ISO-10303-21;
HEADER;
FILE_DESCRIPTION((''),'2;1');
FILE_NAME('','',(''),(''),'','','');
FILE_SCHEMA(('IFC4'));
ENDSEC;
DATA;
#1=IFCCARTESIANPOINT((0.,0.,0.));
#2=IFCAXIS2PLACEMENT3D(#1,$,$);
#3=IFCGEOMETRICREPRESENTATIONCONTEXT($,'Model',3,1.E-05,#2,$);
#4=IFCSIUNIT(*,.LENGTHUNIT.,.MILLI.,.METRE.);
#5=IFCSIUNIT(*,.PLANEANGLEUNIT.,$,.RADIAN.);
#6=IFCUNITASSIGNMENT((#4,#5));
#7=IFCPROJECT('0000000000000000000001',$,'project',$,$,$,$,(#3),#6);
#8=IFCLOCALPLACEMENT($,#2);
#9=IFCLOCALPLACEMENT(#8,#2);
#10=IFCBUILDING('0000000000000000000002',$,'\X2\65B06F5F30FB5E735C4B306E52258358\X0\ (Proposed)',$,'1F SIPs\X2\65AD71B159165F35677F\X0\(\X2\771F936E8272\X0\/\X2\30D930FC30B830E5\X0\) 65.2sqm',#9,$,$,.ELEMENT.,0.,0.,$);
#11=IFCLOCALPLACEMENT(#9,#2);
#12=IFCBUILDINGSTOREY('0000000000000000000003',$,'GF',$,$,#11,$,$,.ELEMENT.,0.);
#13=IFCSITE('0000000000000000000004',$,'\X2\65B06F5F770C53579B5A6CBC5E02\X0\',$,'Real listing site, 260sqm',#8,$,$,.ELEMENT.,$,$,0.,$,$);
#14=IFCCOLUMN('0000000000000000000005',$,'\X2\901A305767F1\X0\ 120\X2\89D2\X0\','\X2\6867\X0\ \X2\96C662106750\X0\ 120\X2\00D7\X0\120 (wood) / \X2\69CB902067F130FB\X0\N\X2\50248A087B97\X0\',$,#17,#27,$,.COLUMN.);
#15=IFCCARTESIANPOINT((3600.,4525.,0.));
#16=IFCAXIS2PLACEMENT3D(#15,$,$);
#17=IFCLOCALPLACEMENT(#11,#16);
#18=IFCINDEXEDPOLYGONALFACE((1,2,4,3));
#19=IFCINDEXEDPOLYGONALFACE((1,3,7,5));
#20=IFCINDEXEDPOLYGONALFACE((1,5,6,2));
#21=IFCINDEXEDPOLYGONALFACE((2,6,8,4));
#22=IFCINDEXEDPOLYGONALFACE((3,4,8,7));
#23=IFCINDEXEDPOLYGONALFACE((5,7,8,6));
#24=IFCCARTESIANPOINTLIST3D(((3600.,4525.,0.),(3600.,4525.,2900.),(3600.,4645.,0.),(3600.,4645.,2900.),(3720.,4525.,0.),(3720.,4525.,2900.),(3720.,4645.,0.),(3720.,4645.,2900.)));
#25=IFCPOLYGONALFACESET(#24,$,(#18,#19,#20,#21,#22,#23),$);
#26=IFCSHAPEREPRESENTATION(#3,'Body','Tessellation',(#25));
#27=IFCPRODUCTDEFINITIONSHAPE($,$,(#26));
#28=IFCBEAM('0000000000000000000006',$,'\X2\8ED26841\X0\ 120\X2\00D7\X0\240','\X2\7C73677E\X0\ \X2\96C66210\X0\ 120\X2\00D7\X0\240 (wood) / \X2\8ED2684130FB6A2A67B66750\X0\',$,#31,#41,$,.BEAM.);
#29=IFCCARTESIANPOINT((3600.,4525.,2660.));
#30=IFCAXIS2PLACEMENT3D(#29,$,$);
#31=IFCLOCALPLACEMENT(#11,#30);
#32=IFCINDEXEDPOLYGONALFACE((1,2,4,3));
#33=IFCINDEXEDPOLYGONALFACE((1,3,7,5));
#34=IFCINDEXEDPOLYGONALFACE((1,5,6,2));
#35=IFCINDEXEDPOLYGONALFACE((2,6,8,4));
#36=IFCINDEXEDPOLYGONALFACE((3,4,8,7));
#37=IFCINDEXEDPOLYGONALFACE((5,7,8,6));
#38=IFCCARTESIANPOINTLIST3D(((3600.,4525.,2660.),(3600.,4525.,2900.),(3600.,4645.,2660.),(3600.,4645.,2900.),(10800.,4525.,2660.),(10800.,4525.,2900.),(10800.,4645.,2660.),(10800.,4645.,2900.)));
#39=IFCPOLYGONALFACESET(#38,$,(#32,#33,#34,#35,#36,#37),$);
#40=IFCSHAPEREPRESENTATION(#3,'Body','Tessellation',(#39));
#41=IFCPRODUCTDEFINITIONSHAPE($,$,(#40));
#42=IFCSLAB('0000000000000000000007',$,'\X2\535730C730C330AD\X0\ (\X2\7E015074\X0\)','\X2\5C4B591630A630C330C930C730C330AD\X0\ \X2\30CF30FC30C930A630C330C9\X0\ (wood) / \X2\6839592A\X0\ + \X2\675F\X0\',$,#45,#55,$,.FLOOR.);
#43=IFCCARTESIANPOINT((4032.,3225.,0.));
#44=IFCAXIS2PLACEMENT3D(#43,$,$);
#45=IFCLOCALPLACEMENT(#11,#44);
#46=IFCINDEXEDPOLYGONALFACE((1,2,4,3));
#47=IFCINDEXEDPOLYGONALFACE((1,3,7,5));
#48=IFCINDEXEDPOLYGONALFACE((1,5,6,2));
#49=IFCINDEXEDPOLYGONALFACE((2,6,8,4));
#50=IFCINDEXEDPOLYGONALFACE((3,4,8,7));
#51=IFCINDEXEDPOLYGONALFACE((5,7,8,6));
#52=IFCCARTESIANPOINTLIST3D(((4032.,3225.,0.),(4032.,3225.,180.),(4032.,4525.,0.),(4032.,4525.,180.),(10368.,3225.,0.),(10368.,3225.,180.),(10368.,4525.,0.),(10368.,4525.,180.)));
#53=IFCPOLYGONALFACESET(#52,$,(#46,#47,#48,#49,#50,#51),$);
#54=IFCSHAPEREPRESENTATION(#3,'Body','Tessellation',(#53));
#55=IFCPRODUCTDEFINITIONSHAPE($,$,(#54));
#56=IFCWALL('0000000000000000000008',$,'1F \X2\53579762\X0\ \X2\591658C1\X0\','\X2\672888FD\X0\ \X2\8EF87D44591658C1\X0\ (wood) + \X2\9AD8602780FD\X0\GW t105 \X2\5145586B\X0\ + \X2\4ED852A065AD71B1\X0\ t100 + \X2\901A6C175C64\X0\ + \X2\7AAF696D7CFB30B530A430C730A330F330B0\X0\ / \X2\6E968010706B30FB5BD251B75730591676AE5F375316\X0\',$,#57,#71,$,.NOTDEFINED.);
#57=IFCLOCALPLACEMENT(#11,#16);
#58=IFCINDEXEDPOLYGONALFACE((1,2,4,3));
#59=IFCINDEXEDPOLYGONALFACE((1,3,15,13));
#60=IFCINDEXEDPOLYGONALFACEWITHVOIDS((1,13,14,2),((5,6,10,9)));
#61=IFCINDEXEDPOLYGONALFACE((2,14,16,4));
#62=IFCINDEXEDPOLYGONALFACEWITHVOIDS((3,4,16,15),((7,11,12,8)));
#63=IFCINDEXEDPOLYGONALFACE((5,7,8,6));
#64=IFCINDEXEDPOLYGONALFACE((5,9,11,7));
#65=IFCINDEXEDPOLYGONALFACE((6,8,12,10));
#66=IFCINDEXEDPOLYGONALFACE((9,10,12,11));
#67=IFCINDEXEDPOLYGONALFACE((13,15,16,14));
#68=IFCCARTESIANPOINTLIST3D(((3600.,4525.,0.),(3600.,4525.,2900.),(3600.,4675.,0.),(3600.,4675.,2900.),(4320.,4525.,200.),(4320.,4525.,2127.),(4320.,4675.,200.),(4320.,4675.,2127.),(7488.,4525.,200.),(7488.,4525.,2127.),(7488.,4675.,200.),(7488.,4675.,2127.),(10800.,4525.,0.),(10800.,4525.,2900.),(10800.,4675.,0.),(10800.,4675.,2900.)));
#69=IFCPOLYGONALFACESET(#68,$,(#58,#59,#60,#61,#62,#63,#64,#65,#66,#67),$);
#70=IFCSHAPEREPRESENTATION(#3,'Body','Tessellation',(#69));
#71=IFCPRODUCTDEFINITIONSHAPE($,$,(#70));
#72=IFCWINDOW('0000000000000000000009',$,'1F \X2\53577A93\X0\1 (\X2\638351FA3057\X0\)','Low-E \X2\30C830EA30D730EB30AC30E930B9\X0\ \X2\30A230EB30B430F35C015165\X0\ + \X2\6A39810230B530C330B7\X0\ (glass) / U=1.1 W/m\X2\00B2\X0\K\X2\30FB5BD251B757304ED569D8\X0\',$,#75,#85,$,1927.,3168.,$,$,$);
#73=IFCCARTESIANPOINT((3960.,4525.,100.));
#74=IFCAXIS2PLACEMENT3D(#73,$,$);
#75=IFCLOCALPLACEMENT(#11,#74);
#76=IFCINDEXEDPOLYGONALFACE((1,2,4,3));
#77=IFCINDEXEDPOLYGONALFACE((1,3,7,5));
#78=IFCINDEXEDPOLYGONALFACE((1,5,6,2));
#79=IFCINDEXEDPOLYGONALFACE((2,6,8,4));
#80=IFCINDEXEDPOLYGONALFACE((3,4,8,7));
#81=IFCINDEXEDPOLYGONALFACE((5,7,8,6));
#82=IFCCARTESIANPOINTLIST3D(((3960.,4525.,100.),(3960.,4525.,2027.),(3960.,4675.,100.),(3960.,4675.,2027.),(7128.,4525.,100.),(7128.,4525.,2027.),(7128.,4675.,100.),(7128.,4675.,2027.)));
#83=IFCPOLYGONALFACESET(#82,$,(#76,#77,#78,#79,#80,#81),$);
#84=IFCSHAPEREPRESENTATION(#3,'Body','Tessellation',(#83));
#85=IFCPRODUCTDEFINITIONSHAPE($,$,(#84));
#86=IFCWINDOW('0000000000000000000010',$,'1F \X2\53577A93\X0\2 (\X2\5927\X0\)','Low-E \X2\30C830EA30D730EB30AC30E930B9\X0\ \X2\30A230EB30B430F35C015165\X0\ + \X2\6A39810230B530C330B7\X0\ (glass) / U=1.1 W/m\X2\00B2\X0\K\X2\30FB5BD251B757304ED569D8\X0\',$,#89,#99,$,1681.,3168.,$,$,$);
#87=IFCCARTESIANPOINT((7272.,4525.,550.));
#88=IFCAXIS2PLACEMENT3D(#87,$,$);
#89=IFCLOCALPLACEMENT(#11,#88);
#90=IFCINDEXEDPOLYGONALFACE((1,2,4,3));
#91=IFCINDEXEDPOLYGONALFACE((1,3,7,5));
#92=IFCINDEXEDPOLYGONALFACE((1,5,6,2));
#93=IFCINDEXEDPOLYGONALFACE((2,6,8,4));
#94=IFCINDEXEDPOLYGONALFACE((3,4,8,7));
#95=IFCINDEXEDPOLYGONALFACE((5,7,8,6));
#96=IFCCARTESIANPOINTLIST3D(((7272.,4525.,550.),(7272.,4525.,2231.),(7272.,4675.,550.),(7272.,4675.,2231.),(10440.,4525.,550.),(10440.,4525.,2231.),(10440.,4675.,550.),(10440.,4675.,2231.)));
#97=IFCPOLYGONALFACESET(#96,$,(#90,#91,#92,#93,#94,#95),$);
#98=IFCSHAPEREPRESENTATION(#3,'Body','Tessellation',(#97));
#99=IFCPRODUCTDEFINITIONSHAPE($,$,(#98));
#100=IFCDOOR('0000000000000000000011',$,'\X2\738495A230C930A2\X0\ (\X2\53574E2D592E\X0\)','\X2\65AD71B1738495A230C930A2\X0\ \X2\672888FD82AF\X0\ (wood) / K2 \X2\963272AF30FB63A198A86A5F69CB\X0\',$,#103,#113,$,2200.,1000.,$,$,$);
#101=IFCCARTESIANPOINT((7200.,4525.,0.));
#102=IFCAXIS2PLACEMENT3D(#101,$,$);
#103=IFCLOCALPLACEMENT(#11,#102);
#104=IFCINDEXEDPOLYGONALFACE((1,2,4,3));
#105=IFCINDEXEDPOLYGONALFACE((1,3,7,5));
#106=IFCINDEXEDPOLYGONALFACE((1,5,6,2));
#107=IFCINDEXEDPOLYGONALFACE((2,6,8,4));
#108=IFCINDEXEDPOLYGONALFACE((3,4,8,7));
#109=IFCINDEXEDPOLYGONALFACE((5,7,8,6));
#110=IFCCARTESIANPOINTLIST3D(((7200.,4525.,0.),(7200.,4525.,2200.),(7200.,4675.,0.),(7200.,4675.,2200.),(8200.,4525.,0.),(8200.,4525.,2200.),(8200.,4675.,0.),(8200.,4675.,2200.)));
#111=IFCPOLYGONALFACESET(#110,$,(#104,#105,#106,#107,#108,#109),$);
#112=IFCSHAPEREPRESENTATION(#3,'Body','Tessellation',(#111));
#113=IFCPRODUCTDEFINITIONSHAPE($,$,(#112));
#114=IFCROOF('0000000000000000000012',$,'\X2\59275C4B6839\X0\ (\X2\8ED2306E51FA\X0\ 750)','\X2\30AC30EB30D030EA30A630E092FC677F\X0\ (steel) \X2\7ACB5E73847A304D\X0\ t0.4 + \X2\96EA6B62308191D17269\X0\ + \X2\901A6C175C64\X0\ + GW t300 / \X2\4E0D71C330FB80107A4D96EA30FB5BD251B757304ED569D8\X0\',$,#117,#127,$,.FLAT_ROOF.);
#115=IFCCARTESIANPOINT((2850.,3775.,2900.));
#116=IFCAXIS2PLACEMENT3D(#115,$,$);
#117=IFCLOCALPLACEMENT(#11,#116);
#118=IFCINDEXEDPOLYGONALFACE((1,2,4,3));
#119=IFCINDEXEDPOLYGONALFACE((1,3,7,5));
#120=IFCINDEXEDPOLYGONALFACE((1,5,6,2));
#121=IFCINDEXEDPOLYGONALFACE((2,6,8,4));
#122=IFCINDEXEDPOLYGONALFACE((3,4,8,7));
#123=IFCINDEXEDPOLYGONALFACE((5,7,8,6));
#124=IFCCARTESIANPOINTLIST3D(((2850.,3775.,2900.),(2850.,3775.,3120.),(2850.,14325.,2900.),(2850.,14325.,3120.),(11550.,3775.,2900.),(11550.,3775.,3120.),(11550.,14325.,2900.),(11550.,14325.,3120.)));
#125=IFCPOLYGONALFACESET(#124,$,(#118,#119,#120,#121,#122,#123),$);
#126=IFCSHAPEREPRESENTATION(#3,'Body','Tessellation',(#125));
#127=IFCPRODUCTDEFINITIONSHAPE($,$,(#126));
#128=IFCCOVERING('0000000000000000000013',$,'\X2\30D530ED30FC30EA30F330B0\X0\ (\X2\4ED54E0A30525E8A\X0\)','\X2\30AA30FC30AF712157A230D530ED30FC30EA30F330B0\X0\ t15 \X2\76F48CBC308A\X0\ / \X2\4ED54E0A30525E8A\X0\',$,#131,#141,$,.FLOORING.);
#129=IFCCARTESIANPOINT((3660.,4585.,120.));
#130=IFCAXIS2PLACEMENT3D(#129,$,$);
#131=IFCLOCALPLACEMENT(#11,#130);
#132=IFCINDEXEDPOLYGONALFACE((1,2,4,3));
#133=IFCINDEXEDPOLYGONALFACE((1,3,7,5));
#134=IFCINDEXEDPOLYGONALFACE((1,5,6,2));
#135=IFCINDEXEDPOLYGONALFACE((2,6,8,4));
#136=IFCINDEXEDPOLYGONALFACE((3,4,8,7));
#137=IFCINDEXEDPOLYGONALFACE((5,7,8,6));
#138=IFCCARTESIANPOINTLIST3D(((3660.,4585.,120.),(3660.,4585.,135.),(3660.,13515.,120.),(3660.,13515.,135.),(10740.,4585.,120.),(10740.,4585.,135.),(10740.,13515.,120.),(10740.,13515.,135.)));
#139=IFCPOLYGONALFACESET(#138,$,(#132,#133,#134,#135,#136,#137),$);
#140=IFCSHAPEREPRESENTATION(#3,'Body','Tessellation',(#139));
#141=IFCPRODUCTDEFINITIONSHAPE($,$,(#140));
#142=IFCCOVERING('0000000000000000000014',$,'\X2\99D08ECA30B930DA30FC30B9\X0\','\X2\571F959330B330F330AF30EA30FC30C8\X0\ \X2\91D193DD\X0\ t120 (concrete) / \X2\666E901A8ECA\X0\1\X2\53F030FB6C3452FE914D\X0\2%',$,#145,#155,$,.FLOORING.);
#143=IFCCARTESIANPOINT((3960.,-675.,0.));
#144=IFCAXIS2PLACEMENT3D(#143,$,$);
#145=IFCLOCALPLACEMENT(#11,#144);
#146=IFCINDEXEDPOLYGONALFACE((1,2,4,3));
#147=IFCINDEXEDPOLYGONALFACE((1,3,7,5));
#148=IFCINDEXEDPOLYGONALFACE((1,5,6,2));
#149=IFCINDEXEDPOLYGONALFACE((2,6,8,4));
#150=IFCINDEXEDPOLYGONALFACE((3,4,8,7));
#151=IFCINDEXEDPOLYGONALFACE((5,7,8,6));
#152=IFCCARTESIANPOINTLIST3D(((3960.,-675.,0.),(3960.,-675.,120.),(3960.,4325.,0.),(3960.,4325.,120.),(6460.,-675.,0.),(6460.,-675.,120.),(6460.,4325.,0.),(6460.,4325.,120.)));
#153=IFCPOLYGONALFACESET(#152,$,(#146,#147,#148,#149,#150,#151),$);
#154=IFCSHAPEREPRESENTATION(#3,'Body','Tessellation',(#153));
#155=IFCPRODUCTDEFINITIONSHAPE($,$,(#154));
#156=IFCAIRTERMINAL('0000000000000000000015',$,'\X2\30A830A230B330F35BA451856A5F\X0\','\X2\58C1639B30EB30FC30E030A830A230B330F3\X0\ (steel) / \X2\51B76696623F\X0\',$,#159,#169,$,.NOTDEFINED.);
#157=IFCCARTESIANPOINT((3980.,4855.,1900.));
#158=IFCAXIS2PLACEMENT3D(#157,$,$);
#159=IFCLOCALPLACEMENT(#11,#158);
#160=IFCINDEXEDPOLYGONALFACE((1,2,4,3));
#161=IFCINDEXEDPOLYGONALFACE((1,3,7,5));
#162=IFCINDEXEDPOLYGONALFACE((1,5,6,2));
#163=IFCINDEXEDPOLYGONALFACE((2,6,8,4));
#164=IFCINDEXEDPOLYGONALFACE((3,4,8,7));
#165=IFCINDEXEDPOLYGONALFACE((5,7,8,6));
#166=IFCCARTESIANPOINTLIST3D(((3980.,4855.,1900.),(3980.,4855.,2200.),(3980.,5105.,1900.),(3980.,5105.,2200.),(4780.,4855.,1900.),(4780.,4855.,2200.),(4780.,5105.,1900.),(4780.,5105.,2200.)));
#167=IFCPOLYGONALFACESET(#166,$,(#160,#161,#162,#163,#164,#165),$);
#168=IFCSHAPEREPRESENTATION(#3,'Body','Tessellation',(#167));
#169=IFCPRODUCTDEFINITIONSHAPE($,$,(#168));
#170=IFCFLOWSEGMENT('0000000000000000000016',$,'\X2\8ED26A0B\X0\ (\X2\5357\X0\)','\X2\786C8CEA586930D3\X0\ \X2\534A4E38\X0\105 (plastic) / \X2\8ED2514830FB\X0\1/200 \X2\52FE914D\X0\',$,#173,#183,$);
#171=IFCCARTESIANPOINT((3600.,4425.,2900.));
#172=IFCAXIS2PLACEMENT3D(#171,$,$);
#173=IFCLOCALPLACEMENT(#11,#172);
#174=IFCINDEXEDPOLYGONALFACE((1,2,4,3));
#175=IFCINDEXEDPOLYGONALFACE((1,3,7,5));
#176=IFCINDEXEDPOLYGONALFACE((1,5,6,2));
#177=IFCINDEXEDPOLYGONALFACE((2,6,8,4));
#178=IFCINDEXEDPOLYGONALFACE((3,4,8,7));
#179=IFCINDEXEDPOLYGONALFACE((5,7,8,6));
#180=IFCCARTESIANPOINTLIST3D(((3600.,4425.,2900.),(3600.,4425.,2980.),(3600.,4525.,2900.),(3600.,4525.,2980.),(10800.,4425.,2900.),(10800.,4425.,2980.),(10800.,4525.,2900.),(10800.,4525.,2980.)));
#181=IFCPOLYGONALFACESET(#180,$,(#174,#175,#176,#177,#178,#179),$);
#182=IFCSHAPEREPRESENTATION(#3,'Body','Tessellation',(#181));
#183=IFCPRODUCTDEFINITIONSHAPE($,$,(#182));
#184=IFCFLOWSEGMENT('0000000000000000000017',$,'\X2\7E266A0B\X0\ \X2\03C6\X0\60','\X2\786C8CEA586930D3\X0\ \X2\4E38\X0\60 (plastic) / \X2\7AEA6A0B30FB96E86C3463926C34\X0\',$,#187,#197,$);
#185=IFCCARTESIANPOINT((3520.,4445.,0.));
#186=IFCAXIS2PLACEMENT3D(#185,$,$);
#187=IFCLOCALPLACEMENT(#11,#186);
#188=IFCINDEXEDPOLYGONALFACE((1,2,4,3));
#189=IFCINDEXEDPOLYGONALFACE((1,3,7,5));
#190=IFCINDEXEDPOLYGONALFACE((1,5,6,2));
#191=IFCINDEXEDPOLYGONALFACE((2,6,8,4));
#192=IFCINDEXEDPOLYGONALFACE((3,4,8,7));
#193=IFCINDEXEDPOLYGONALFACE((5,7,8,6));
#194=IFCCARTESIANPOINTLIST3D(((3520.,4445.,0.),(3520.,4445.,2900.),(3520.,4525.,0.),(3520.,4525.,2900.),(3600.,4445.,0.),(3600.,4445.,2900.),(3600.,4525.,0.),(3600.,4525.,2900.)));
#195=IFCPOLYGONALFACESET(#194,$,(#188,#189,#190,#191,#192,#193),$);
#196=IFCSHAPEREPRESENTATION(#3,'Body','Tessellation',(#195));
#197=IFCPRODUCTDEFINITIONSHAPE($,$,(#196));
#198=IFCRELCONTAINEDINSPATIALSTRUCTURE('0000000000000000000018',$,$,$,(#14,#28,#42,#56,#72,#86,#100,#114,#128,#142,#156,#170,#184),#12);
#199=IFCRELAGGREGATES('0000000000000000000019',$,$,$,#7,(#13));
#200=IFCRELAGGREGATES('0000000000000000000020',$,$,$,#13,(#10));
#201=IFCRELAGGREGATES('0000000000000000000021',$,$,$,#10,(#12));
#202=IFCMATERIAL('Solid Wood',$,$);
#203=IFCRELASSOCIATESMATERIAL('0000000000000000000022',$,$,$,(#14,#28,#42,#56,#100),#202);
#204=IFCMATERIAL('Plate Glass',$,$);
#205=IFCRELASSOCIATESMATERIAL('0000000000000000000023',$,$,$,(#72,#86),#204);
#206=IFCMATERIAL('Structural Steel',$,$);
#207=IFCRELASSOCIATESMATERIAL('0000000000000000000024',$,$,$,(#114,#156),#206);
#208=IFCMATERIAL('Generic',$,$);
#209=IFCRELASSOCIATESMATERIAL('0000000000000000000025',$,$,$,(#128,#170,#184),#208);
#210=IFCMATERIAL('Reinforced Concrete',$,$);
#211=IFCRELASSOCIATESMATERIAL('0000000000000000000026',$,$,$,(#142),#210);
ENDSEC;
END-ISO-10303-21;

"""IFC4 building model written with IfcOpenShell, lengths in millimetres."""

from ifc_helpers import new_model, si_unit, frame, frame_2d, origin, place, context, project, spatial, rectangle, extrude, material, element, fill, save


model = new_model("IFC4")

# Units and contexts
model_context = context("Model", 3, precision=1e-05, world=origin())
ifc_project = project(units=[si_unit("LENGTHUNIT", "METRE", prefix="MILLI"), si_unit("PLANEANGLEUNIT", "RADIAN")], contexts=[model_context])

# Site, building, storey
site_placement = place(None, origin())
site = spatial("IfcSite", under=ifc_project, at=site_placement, Name="新潟県南魚沼市", ObjectType="Real listing site, 260sqm", CompositionType="ELEMENT", RefElevation=0.0)
building_placement = place(site_placement, origin())
building = spatial("IfcBuilding", under=site, at=building_placement, Name="新潟・平屋の別荘 (Proposed)", ObjectType="1F SIPs断熱外張板(真鍮色/ベージュ) 65.2sqm", CompositionType="ELEMENT", ElevationOfRefHeight=0.0, ElevationOfTerrain=0.0)
storey_placement = place(building_placement, origin())
storey = spatial("IfcBuildingStorey", under=building, at=storey_placement, Name="GF", CompositionType="ELEMENT", Elevation=0.0)

# Column
ifc_material_1 = material(Name="Solid Wood")
column_1_placement = place(storey_placement, frame((3600.0, 4525.0, 0.0)))
element("IfcColumn", 1, at=column_1_placement, inside=storey, material=ifc_material_1, Name="通し柱 120角", Description="桧 集成材 120×120 (wood) / 構造柱・N値計算", PredefinedType="COLUMN", context=model_context, shape_type="SweptSolid", body=[
    extrude(rectangle(XDim=120.0, YDim=120.0, at=frame_2d((60.0, 60.0))), frame((3600.0, 4525.0, 0.0)), (0.0, 0.0, 1.0), 2900.0),
])

# Beam
beam_1_placement = place(storey_placement, frame((3600.0, 4525.0, 2660.0)))
element("IfcBeam", 2, at=beam_1_placement, inside=storey, material=ifc_material_1, Name="軒桁 120×240", Description="米松 集成 120×240 (wood) / 軒桁・横架材", PredefinedType="BEAM", context=model_context, shape_type="SweptSolid", body=[
    extrude(rectangle(XDim=7200.0, YDim=120.0, at=frame_2d((3600.0, 60.0))), frame((3600.0, 4525.0, 2660.0)), (0.0, 0.0, 1.0), 240.0),
])

# Slab
ifc_material_2 = material(Name="Reinforced Concrete")
slab_1_placement = place(storey_placement, frame((4032.0, 3225.0, 0.0)))
element("IfcSlab", 3, at=slab_1_placement, inside=storey, material=ifc_material_1, Name="南デッキ (縁側)", Description="屋外ウッドデッキ ハードウッド (wood) / 根太 + 束", PredefinedType="FLOOR", context=model_context, shape_type="SweptSolid", body=[
    extrude(rectangle(XDim=6336.0, YDim=1300.0, at=frame_2d((3168.0, 650.0))), frame((4032.0, 3225.0, 0.0)), (0.0, 0.0, 1.0), 180.0),
])

# Wall, openings, windows, door
wall_1_placement = place(storey_placement, frame((3600.0, 4525.0, 0.0)))
wall_1 = element("IfcWall", 4, at=wall_1_placement, inside=storey, material=ifc_material_1, Name="1F 南面 外壁", Description="木製 軸組外壁 (wood) + 高性能GW t105 充填 + 付加断熱 t100 + 通気層 + 窯業系サイディング / 準耐火・寒冷地外皮強化", PredefinedType="NOTDEFINED", context=model_context, shape_type="SweptSolid", body=[
    extrude(rectangle(XDim=7200.0, YDim=150.0, at=frame_2d((3600.0, 75.0))), frame((3600.0, 4525.0, 0.0)), (0.0, 0.0, 1.0), 2900.0),
])
opening_1_placement = place(storey_placement, frame((3960.0, 4525.0, 100.0)))
opening_1 = element("IfcOpeningElement", 5, at=opening_1_placement, cuts=wall_1, PredefinedType="NOTDEFINED", context=model_context, shape_type="SweptSolid", body=[
    extrude(rectangle(XDim=3168.0, YDim=150.0, at=frame_2d((1584.0, 75.0))), frame((3960.0, 4525.0, 100.0)), (0.0, 0.0, 1.0), 1927.0),
])
opening_2_placement = place(storey_placement, frame((7272.0, 4525.0, 550.0)))
opening_2 = element("IfcOpeningElement", 6, at=opening_2_placement, cuts=wall_1, PredefinedType="NOTDEFINED", context=model_context, shape_type="SweptSolid", body=[
    extrude(rectangle(XDim=3168.0, YDim=150.0, at=frame_2d((1584.0, 75.0))), frame((7272.0, 4525.0, 550.0)), (0.0, 0.0, 1.0), 1681.0),
])
opening_3_placement = place(storey_placement, frame((7200.0, 4525.0, 0.0)))
opening_3 = element("IfcOpeningElement", 7, at=opening_3_placement, cuts=wall_1, PredefinedType="NOTDEFINED", context=model_context, shape_type="SweptSolid", body=[
    extrude(rectangle(XDim=1000.0, YDim=150.0, at=frame_2d((500.0, 75.0))), frame((7200.0, 4525.0, 0.0)), (0.0, 0.0, 1.0), 2200.0),
])
ifc_material_3 = material(Name="Plate Glass")
window_1_placement = place(storey_placement, frame((3960.0, 4525.0, 100.0)))
window_1 = element("IfcWindow", 8, at=window_1_placement, inside=storey, material=ifc_material_3, Name="1F 南窓1 (掃出し)", Description="Low-E トリプルガラス アルゴン封入 + 樹脂サッシ (glass) / U=1.1 W/m²K・寒冷地仕様", OverallHeight=1927.0, OverallWidth=3168.0, context=model_context, shape_type="SweptSolid", body=[
    extrude(rectangle(XDim=3168.0, YDim=150.0, at=frame_2d((1584.0, 75.0))), frame((3960.0, 4525.0, 100.0)), (0.0, 0.0, 1.0), 1927.0),
])
fill(opening_1, window_1)
window_2_placement = place(storey_placement, frame((7272.0, 4525.0, 550.0)))
window_2 = element("IfcWindow", 9, at=window_2_placement, inside=storey, material=ifc_material_3, Name="1F 南窓2 (大)", Description="Low-E トリプルガラス アルゴン封入 + 樹脂サッシ (glass) / U=1.1 W/m²K・寒冷地仕様", OverallHeight=1681.0, OverallWidth=3168.0, context=model_context, shape_type="SweptSolid", body=[
    extrude(rectangle(XDim=3168.0, YDim=150.0, at=frame_2d((1584.0, 75.0))), frame((7272.0, 4525.0, 550.0)), (0.0, 0.0, 1.0), 1681.0),
])
fill(opening_2, window_2)
door_placement = place(storey_placement, frame((7200.0, 4525.0, 0.0)))
door = element("IfcDoor", 10, at=door_placement, inside=storey, material=ifc_material_1, Name="玄関ドア (南中央)", Description="断熱玄関ドア 木製芯 (wood) / K2 防犯・採風機構", OverallHeight=2200.0, OverallWidth=1000.0, context=model_context, shape_type="SweptSolid", body=[
    extrude(rectangle(XDim=1000.0, YDim=150.0, at=frame_2d((500.0, 75.0))), frame((7200.0, 4525.0, 0.0)), (0.0, 0.0, 1.0), 2200.0),
])
fill(opening_3, door)

# Roof
ifc_material_4 = material(Name="Structural Steel")
roof_placement = place(storey_placement, frame((2850.0, 3775.0, 2900.0)))
element("IfcRoof", 11, at=roof_placement, inside=storey, material=ifc_material_4, Name="大屋根 (軒の出 750)", Description="ガルバリウム鋼板 (steel) 立平葺き t0.4 + 雪止め金物 + 通気層 + GW t300 / 不燃・耐積雪・寒冷地仕様", PredefinedType="FLAT_ROOF", context=model_context, shape_type="SweptSolid", body=[
    extrude(rectangle(XDim=8700.0, YDim=10550.0, at=frame_2d((4350.0, 5275.0))), frame((2850.0, 3775.0, 2900.0)), (0.0, 0.0, 1.0), 220.0),
])

# Coverings
ifc_material_5 = material(Name="Generic")
covering_1_placement = place(storey_placement, frame((3660.0, 4585.0, 120.0)))
element("IfcCovering", 12, at=covering_1_placement, inside=storey, material=ifc_material_5, Name="フローリング (仕上げ床)", Description="オーク無垢フローリング t15 直貼り / 仕上げ床", PredefinedType="FLOORING", context=model_context, shape_type="SweptSolid", body=[
    extrude(rectangle(XDim=7080.0, YDim=8930.0, at=frame_2d((3540.0, 4465.0))), frame((3660.0, 4585.0, 120.0)), (0.0, 0.0, 1.0), 15.0),
])
covering_2_placement = place(storey_placement, frame((3960.0, -675.0, 0.0)))
element("IfcCovering", 13, at=covering_2_placement, inside=storey, material=ifc_material_2, Name="駐車スペース", Description="土間コンクリート 金鏝 t120 (concrete) / 普通車1台・水勾配2%", PredefinedType="FLOORING", context=model_context, shape_type="SweptSolid", body=[
    extrude(rectangle(XDim=2500.0, YDim=5000.0, at=frame_2d((1250.0, 2500.0))), frame((3960.0, -675.0, 0.0)), (0.0, 0.0, 1.0), 120.0),
])

# Air terminal
air_terminal_placement = place(storey_placement, frame((3980.0, 4855.0, 1900.0)))
element("IfcAirTerminal", 14, at=air_terminal_placement, inside=storey, material=ifc_material_4, Name="エアコン室内機", Description="壁掛ルームエアコン (steel) / 冷暖房", PredefinedType="NOTDEFINED", context=model_context, shape_type="SweptSolid", body=[
    extrude(rectangle(XDim=800.0, YDim=250.0, at=frame_2d((400.0, 125.0))), frame((3980.0, 4855.0, 1900.0)), (0.0, 0.0, 1.0), 300.0),
])

# Flow segments
flow_segment_1_placement = place(storey_placement, frame((3600.0, 4425.0, 2900.0)))
element("IfcFlowSegment", 15, at=flow_segment_1_placement, inside=storey, material=ifc_material_5, Name="軒樋 (南)", Description="硬質塩ビ 半丸105 (plastic) / 軒先・1/200 勾配", context=model_context, shape_type="SweptSolid", body=[
    extrude(rectangle(XDim=7200.0, YDim=100.0, at=frame_2d((3600.0, 50.0))), frame((3600.0, 4425.0, 2900.0)), (0.0, 0.0, 1.0), 80.0),
])
flow_segment_2_placement = place(storey_placement, frame((3520.0, 4445.0, 0.0)))
element("IfcFlowSegment", 16, at=flow_segment_2_placement, inside=storey, material=ifc_material_5, Name="縦樋 φ60", Description="硬質塩ビ 丸60 (plastic) / 竪樋・雨水排水", context=model_context, shape_type="SweptSolid", body=[
    extrude(rectangle(XDim=80.0, YDim=80.0, at=frame_2d((40.0, 40.0))), frame((3520.0, 4445.0, 0.0)), (0.0, 0.0, 1.0), 2900.0),
])

save(model, "model.ifc")
